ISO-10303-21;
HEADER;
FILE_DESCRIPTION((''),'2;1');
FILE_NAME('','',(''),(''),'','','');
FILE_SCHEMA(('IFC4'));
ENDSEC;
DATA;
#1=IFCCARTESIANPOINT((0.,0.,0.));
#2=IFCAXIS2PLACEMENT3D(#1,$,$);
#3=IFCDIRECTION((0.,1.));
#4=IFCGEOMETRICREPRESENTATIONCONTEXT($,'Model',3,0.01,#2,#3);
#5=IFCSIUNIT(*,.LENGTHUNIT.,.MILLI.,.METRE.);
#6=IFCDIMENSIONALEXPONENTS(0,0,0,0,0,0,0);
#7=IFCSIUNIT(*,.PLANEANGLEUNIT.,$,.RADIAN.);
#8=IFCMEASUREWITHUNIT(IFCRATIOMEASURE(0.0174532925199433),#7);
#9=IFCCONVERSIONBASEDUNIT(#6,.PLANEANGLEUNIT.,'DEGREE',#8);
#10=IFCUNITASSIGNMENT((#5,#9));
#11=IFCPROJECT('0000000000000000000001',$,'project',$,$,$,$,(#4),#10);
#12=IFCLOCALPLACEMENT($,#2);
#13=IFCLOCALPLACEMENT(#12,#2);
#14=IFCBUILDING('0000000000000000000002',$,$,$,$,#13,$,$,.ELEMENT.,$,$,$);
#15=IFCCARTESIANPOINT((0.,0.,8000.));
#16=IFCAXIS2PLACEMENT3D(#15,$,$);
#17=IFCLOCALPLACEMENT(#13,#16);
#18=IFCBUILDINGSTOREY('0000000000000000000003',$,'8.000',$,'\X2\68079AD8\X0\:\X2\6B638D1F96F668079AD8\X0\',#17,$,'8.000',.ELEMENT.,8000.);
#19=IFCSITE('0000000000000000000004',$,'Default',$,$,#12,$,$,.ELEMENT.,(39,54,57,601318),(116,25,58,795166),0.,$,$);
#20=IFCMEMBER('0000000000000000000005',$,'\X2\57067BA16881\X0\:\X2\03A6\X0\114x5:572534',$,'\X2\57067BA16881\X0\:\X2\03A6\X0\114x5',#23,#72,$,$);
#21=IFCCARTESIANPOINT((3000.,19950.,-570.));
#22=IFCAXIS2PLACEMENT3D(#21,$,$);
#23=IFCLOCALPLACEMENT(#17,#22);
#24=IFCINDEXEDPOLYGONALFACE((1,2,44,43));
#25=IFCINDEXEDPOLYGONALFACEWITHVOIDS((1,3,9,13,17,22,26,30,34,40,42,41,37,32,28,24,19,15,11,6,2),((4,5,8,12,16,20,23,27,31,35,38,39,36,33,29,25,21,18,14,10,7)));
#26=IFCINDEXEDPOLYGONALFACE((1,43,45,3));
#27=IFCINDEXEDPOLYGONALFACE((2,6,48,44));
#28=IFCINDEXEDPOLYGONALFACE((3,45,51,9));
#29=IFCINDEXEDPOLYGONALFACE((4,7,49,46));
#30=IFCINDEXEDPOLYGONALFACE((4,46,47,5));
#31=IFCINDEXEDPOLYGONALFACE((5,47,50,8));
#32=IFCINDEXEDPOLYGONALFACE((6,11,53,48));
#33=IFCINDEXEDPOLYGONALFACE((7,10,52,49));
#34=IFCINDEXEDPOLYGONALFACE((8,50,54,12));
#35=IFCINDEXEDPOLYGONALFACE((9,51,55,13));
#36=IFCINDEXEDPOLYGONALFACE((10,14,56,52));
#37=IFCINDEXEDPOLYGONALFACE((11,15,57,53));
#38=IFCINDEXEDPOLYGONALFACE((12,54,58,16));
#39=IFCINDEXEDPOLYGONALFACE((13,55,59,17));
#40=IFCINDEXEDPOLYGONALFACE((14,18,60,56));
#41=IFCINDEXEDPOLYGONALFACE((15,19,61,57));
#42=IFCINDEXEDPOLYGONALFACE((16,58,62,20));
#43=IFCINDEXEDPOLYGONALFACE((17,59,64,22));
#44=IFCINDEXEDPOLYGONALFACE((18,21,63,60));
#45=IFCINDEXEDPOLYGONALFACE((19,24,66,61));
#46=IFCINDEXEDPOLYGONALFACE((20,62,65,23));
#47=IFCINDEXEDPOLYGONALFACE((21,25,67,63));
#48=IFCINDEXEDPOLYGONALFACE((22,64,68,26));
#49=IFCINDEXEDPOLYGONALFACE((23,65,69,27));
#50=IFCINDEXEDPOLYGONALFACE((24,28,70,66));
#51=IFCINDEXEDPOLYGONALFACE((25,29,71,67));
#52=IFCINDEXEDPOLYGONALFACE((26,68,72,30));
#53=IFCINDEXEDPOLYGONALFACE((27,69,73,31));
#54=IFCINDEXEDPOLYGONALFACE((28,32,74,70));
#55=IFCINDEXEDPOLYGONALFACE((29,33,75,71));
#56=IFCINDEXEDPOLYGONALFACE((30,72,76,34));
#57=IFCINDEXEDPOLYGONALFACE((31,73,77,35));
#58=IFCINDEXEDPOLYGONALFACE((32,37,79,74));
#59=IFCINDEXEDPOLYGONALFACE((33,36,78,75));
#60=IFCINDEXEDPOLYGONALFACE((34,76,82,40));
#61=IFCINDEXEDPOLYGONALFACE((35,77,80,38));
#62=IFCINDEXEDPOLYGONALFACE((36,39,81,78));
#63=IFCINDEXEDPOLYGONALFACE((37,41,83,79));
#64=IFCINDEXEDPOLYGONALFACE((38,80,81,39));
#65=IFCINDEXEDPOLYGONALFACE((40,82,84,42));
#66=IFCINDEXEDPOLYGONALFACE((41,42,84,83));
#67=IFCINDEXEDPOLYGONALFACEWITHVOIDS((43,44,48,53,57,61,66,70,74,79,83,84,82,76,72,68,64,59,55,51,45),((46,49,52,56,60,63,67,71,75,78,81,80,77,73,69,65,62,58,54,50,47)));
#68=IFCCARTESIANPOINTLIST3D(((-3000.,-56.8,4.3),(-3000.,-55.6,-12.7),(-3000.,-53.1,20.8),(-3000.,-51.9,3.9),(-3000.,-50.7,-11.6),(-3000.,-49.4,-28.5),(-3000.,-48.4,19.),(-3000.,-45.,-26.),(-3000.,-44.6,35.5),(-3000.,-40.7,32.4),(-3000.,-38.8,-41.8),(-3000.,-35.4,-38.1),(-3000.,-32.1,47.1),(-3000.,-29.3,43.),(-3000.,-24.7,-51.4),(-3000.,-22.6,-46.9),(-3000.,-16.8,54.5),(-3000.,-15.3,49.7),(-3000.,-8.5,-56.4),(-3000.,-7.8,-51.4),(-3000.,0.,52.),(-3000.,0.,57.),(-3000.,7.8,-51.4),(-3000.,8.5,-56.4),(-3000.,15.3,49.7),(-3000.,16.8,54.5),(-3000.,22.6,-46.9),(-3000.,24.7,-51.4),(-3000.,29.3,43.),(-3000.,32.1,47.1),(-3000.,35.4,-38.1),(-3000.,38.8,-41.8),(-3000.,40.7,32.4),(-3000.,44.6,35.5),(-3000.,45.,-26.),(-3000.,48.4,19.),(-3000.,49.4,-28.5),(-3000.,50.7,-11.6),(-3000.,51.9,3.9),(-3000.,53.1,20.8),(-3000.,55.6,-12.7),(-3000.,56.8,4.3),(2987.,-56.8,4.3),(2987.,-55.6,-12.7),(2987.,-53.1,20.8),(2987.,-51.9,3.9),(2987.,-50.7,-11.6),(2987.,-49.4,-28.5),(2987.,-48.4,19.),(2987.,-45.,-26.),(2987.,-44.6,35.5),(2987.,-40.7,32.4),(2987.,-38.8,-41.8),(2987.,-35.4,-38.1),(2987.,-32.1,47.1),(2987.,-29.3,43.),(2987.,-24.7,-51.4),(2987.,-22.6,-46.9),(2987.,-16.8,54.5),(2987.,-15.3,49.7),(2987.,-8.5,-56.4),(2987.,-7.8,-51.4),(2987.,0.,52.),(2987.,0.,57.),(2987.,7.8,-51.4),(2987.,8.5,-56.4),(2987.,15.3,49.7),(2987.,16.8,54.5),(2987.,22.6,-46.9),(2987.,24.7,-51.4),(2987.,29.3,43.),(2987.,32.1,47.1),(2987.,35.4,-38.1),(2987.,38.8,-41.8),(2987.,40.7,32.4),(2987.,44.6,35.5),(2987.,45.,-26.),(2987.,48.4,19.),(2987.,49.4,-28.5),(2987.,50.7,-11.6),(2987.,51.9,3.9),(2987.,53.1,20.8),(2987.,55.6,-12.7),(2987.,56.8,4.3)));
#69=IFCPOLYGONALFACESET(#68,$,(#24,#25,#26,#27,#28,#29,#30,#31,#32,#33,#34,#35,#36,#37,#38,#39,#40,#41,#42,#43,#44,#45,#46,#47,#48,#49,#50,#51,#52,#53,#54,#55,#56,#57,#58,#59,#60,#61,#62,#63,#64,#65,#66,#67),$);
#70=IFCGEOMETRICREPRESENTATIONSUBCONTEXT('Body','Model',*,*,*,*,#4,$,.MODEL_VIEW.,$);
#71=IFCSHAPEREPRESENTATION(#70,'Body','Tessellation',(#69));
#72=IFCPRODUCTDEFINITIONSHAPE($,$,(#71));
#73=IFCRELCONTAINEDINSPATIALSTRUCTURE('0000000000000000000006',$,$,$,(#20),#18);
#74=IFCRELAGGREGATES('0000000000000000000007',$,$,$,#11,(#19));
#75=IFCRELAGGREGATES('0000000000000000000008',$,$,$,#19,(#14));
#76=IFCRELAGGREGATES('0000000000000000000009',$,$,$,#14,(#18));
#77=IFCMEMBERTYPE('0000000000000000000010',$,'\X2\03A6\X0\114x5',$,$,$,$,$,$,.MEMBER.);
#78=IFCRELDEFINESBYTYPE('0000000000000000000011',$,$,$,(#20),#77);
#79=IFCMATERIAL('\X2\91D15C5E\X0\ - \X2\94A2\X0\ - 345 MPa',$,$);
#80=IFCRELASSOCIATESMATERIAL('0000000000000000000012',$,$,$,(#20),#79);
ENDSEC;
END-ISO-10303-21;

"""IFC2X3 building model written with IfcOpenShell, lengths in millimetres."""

from ifc_helpers import new_model, entity, si_unit, converted_unit, direction, frame, frame_2d, origin, place, context, subcontext, project, spatial, hollow_circle, extrude, source, transform, mapped, material, type_object, type_shapes, element, save


model = new_model("IFC2X3")

# Units and contexts
model_context = context("Model", 3, precision=0.01, world=origin(), true_north=direction((0.0, 1.0)))
body_context = subcontext(model_context, "Body", "Model", "MODEL_VIEW")
ifc_project = project(units=[si_unit("LENGTHUNIT", "METRE", prefix="MILLI"), converted_unit("PLANEANGLEUNIT", "DEGREE", entity("IfcRatioMeasure", 0.0174532925199433), si_unit("PLANEANGLEUNIT", "RADIAN"), dimensions=[0, 0, 0, 0, 0, 0, 0])], contexts=[model_context])

# Site, building, storey
site_placement = place(None, origin())
site = spatial("IfcSite", under=ifc_project, at=site_placement, Name="Default", CompositionType="ELEMENT", RefLatitude=(39, 54, 57, 601318), RefLongitude=(116, 25, 58, 795166), RefElevation=0.0)
building_placement = place(site_placement, origin())
building = spatial("IfcBuilding", under=site, at=building_placement, CompositionType="ELEMENT")
storey_placement = place(building_placement, frame((0.0, 0.0, 8000.0)))
storey = spatial("IfcBuildingStorey", under=building, at=storey_placement, Name="8.000", ObjectType="标高:正负零标高", LongName="8.000", CompositionType="ELEMENT", Elevation=8000.0)

# Shared definitions
ifc_material_1 = material(Name="金属 - 钢 - 345 MPa")

# Member
member_type_1 = type_object("IfcMemberType", Name="Φ114x5", PredefinedType="MEMBER")
shared_shape_1 = source(origin(), body_context, "Body", "SweptSolid", [
    extrude(hollow_circle(Radius=57.0, WallThickness=5.0, at=frame_2d((0.0, 0.0), x_axis=(1.0, 0.0))), frame((-3000.0, 0.0, 0.0), z_axis=(1.0, 0.0, 0.0), x_axis=(0.0, 0.0, 1.0)), (0.0, 0.0, 1.0), 5987.0),
])
type_shapes(member_type_1, [shared_shape_1])
for number, where, name in (
    (1, (3000.0, 19950.0, -570.0), "圆管梁:Φ114x5:572534"),
):
    element("IfcMember", number, at=place(storey_placement, frame(where)), inside=storey, type_object=member_type_1, material=ifc_material_1, Name=name, ObjectType="圆管梁:Φ114x5", context=body_context, shape_type="MappedRepresentation", body=[
        mapped(shared_shape_1, transform((0.0, 0.0, 0.0), scale=1.0)),
    ])

save(model, "model.ifc")
